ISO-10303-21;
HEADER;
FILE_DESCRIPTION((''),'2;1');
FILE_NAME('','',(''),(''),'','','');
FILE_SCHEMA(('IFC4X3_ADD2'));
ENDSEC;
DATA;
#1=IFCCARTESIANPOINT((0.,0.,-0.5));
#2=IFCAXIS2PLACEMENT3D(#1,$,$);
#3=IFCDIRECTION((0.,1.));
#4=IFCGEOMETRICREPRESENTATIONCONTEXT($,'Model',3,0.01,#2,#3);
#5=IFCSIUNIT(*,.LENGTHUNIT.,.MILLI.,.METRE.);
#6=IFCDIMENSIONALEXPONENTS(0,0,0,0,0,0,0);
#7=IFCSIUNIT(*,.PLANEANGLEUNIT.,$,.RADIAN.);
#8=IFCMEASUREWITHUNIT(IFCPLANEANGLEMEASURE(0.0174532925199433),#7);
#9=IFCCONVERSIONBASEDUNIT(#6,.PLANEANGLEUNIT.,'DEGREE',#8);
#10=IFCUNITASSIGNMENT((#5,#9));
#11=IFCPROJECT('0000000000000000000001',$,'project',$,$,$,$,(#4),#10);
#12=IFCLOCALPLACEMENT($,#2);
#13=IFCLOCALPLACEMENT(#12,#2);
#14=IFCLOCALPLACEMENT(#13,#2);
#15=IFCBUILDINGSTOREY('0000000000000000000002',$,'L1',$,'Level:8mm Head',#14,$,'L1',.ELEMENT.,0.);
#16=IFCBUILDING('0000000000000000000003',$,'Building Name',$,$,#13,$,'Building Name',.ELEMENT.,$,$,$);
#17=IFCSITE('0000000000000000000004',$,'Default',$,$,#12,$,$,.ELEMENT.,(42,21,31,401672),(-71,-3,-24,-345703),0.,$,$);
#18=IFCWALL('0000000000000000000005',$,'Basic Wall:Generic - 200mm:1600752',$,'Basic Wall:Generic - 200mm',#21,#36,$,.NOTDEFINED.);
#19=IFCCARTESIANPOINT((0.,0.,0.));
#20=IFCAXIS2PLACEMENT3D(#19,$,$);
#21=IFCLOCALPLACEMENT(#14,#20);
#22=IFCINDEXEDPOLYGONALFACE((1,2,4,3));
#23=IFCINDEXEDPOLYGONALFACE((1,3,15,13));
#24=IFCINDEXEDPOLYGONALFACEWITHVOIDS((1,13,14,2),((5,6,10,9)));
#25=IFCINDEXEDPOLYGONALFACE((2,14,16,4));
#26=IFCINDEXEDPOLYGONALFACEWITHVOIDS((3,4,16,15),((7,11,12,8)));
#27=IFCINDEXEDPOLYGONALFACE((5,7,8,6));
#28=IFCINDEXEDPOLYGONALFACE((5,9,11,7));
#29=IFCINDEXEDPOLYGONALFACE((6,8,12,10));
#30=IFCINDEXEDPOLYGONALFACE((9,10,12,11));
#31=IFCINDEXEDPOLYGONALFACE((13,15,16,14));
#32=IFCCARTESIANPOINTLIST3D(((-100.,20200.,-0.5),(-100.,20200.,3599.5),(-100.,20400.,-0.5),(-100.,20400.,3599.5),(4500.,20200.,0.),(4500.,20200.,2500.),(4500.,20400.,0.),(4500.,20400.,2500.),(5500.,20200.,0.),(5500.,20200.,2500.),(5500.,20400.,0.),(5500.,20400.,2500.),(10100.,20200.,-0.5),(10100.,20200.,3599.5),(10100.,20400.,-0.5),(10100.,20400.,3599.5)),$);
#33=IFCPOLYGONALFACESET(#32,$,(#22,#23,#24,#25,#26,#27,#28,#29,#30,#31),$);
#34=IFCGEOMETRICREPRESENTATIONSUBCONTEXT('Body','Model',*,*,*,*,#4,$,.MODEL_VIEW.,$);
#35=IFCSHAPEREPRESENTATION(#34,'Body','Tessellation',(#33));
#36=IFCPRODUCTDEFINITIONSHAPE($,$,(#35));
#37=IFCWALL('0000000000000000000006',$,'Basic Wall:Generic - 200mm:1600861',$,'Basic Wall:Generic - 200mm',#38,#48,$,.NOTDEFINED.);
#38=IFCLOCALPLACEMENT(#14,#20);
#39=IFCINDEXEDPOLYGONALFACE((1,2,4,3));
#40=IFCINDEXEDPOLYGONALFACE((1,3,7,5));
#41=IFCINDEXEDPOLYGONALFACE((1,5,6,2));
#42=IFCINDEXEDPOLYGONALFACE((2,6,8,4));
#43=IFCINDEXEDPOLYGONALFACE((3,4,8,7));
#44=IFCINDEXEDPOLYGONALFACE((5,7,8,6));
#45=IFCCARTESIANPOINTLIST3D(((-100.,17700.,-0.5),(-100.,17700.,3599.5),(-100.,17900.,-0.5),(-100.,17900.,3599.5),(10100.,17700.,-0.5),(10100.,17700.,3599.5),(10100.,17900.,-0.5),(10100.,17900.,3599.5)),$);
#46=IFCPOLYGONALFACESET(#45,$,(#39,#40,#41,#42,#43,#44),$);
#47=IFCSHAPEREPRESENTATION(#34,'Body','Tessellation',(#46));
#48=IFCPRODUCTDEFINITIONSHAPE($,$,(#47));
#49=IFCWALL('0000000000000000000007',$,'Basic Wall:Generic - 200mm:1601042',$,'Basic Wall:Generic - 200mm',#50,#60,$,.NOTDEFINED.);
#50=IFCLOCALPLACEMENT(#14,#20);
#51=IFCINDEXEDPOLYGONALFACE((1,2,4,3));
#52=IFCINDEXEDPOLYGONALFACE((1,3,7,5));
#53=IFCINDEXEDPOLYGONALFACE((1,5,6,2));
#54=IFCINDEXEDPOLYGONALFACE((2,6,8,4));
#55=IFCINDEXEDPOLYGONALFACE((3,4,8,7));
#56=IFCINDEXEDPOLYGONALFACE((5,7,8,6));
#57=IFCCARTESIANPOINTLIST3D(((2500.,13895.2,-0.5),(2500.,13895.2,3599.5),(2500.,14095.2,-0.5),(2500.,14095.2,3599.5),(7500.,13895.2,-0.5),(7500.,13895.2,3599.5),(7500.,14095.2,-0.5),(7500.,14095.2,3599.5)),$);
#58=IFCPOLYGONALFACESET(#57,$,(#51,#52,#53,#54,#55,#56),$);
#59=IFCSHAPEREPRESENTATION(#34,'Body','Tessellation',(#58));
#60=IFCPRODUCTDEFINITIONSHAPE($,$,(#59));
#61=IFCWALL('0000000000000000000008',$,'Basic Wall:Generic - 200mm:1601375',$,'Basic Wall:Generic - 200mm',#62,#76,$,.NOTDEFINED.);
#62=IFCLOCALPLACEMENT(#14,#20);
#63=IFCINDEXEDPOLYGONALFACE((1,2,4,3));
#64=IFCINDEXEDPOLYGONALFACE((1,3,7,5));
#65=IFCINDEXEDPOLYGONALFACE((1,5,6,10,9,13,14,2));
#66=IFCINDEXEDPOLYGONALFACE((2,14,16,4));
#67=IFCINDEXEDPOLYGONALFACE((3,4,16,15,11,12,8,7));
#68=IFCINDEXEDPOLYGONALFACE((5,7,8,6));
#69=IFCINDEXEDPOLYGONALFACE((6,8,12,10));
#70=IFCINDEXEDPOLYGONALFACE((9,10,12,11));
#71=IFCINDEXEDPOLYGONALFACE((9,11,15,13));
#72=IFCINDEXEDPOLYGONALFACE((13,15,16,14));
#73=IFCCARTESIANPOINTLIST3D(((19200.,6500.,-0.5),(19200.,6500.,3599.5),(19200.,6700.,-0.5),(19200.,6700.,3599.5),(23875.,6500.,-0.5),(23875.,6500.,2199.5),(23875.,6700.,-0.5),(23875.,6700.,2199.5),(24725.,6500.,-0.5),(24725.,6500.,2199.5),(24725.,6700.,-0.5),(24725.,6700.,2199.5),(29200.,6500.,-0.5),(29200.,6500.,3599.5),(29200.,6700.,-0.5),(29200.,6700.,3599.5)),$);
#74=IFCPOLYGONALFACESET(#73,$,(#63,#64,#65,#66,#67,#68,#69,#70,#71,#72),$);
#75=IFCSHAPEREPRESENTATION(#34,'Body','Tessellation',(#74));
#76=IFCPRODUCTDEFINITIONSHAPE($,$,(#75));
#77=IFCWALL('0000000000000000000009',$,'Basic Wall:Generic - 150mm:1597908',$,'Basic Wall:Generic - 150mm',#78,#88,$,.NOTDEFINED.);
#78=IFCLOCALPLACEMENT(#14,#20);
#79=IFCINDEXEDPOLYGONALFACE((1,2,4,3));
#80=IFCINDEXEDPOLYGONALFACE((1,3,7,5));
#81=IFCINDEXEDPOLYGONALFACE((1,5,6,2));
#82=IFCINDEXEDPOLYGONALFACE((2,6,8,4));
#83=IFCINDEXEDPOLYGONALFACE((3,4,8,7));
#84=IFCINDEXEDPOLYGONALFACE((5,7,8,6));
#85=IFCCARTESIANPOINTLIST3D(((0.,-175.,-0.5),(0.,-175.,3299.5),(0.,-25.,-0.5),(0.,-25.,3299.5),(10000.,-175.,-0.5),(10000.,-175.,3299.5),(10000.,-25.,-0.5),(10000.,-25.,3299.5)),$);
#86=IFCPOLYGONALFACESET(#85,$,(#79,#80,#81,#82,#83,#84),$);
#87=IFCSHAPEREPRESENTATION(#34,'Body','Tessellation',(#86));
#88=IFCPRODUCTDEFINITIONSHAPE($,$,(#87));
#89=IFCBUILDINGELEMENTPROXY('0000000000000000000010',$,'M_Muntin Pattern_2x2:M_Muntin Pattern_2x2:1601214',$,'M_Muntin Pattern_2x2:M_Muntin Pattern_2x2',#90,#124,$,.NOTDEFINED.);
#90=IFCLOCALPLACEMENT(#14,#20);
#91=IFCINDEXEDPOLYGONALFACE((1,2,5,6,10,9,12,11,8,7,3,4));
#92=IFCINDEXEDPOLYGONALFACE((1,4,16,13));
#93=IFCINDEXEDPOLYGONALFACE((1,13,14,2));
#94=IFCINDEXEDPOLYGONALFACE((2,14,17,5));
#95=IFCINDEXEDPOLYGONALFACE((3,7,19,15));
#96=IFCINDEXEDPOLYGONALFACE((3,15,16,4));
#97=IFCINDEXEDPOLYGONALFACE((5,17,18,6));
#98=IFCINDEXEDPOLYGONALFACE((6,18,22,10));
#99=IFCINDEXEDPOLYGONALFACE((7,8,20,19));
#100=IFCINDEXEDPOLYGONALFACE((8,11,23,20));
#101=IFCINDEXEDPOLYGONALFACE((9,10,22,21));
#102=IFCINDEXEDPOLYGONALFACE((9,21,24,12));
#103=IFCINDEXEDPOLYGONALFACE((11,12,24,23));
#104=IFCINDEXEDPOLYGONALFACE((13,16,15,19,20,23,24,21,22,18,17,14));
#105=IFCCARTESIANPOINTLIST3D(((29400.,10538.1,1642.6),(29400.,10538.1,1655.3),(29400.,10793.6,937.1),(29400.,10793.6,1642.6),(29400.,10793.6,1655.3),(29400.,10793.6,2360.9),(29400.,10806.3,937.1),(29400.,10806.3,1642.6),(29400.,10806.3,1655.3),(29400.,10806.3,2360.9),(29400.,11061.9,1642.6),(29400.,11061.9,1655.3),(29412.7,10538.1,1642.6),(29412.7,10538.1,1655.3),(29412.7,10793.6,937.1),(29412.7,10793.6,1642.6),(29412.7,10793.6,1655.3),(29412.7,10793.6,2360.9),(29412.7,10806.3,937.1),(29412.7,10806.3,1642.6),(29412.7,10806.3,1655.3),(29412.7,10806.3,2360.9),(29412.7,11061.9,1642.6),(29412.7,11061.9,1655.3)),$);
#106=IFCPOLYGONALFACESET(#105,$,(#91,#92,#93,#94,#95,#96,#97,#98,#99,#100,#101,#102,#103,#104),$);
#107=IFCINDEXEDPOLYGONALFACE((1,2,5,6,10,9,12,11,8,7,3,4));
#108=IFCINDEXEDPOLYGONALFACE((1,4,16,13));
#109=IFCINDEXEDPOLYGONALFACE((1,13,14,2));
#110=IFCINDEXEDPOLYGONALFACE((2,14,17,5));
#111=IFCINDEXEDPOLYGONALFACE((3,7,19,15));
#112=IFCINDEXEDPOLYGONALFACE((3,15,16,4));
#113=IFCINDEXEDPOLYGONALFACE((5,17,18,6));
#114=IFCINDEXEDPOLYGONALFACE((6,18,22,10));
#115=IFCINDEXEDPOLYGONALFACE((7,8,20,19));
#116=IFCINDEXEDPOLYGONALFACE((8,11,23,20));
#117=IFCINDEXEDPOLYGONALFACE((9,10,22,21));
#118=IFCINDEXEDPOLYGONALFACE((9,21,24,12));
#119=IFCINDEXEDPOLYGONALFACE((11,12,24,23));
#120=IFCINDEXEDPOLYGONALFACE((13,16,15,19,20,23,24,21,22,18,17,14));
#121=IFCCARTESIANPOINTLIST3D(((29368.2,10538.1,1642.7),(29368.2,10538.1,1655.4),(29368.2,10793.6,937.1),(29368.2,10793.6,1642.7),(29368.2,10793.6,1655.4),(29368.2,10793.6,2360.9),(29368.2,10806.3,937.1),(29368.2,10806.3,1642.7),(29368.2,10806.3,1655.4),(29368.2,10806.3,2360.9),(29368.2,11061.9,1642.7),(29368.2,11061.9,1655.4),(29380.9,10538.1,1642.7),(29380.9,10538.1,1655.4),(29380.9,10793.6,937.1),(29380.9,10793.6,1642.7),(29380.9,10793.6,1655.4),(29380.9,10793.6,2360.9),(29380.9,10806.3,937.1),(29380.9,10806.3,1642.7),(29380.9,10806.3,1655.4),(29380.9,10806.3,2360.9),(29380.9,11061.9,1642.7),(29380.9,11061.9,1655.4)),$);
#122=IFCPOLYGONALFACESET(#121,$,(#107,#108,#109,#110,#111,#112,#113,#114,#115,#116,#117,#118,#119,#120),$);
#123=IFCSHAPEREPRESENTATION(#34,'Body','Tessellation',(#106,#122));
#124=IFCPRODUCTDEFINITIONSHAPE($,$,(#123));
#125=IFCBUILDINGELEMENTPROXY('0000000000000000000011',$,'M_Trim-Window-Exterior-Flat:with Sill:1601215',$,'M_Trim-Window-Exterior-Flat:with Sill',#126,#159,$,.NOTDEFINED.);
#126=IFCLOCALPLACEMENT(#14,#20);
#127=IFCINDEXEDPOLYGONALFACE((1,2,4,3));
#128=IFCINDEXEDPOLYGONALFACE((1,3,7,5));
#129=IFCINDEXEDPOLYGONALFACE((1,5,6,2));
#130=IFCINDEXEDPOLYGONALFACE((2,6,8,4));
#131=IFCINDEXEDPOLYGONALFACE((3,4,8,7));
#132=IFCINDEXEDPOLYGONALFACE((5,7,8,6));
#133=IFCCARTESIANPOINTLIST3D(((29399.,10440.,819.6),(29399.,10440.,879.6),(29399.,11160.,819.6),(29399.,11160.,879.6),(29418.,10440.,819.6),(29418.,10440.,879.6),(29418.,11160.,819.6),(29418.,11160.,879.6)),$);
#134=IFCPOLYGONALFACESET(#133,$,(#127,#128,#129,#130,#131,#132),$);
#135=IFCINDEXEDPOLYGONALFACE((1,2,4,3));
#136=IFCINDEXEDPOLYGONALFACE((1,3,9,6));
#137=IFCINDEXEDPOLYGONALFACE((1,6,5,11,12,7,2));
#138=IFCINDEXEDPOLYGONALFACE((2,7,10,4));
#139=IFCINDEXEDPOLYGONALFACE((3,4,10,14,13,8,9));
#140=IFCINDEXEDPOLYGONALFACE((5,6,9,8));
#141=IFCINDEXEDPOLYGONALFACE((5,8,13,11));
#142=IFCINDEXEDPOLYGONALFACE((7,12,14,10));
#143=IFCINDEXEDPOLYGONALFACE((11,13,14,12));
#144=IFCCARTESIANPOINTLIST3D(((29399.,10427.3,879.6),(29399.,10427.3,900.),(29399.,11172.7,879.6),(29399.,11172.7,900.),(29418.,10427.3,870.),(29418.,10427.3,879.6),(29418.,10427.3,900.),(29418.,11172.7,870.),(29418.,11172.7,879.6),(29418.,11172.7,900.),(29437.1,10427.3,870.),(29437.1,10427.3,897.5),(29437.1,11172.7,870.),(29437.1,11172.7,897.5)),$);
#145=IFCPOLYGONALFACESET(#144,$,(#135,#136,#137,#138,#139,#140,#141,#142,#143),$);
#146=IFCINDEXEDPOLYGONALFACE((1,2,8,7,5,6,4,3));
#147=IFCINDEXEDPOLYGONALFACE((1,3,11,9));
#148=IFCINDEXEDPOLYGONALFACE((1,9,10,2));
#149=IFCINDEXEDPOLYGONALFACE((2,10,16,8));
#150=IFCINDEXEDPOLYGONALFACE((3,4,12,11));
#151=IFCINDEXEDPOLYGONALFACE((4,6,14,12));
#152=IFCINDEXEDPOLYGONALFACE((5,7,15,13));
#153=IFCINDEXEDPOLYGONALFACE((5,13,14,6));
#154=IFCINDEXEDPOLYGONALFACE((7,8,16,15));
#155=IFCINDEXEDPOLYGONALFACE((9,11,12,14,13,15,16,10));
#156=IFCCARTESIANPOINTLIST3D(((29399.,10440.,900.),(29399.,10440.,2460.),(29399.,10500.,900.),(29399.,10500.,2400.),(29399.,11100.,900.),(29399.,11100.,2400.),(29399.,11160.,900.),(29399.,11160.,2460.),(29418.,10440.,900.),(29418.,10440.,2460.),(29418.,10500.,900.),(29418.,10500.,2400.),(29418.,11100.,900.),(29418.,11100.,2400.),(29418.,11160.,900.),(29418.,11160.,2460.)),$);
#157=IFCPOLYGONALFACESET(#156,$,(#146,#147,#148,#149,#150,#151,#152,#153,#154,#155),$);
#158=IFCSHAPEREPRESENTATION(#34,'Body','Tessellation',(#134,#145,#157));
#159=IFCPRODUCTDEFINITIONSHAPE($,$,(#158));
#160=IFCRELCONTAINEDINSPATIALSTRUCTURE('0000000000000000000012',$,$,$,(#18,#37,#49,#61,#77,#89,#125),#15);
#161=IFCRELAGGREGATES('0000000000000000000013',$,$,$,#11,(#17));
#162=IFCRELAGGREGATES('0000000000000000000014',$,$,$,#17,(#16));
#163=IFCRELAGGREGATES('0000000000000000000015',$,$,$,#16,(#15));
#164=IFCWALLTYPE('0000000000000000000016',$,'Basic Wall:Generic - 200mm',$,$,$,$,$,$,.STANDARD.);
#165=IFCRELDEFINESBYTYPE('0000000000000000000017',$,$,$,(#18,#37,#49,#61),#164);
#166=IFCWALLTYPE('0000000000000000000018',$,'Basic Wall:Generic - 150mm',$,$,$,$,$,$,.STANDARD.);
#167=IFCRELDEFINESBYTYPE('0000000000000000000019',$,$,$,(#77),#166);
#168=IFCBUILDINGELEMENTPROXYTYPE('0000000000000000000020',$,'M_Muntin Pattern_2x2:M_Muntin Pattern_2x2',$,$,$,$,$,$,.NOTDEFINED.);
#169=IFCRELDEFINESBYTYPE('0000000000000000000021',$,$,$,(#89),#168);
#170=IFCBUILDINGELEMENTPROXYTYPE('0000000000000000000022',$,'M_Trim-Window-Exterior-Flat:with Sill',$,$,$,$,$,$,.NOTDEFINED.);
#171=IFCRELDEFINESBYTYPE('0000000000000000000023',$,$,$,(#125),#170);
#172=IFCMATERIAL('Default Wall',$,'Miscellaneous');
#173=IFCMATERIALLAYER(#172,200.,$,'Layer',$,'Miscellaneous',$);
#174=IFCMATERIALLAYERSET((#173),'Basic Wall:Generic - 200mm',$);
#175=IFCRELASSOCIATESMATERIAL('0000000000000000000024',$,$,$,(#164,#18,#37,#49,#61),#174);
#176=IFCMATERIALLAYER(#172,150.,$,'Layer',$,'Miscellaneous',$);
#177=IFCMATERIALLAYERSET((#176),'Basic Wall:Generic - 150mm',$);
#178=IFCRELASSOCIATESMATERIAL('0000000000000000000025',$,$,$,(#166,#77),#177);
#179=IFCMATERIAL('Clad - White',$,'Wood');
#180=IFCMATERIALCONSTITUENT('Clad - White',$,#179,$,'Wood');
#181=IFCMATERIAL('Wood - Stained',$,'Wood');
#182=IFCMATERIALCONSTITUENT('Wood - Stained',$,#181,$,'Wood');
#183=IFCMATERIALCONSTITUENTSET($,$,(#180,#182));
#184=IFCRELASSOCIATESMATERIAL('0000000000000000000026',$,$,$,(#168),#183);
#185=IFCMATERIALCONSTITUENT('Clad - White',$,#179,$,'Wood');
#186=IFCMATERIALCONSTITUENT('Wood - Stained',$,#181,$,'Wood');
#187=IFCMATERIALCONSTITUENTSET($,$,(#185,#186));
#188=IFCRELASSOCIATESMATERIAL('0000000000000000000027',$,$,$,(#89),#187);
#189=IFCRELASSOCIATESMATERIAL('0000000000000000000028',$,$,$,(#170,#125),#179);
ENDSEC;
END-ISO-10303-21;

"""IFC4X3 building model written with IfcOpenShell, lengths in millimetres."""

from ifc_helpers import new_model, entity, si_unit, converted_unit, direction, frame, frame_2d, origin_2d_with_axis, place, context, subcontext, project, spatial, polyline, rectangle, outline, extrude, source, transform, mapped, material, layer, layer_set, constituent, constituent_set, type_object, type_shapes, element, save


model = new_model("IFC4X3")

# Units and contexts
model_context = context("Model", 3, precision=0.01, world=frame((0.0, 0.0, -0.5)), true_north=direction((0.0, 1.0)))
body_context = subcontext(model_context, "Body", "Model", "MODEL_VIEW")
ifc_project = project(units=[si_unit("LENGTHUNIT", "METRE", prefix="MILLI"), converted_unit("PLANEANGLEUNIT", "DEGREE", entity("IfcPlaneAngleMeasure", 0.0174532925199433), si_unit("PLANEANGLEUNIT", "RADIAN"), dimensions=[0, 0, 0, 0, 0, 0, 0])], contexts=[model_context])

# Site, building, storey
site_placement = place(None, frame((0.0, 0.0, -0.5)))
site = spatial("IfcSite", under=ifc_project, at=site_placement, Name="Default", CompositionType="ELEMENT", RefLatitude=(42, 21, 31, 401672), RefLongitude=(-71, -3, -24, -345703), RefElevation=0.0)
building_placement = place(site_placement, frame((0.0, 0.0, -0.5)))
building = spatial("IfcBuilding", under=site, at=building_placement, Name="Building Name", LongName="Building Name", CompositionType="ELEMENT")
storey_placement = place(building_placement, frame((0.0, 0.0, -0.5)))
storey = spatial("IfcBuildingStorey", under=building, at=storey_placement, Name="L1", ObjectType="Level:8mm Head", LongName="L1", CompositionType="ELEMENT", Elevation=0.0)

# Shared definitions
ifc_material_1 = material(Name="Default Wall", Category="Miscellaneous")
ifc_layer_1 = layer(ifc_material_1, 200.0, Name="Layer", Category="Miscellaneous")
ifc_layer_set_1 = layer_set([ifc_layer_1], Name="Basic Wall:Generic - 200mm")
wall_type_1 = type_object("IfcWallType", Name="Basic Wall:Generic - 200mm", PredefinedType="STANDARD", material=ifc_layer_set_1)

# Wall, opening
wall_1_placement = place(storey_placement, frame((10100.0, 20300.0, 0.0), z_axis=(0.0, 0.0, 1.0), x_axis=(-1.0, 0.0, 0.0)))
wall_1 = element("IfcWall", 1, at=wall_1_placement, inside=storey, type_object=wall_type_1, material=ifc_layer_set_1, Name="Basic Wall:Generic - 200mm:1600752", ObjectType="Basic Wall:Generic - 200mm", PredefinedType="NOTDEFINED", context=body_context, shape_type="SweptSolid", body=[
    extrude(rectangle(XDim=10200.0, YDim=200.0, at=frame_2d((5100.0, 0.0), x_axis=(1.0, 0.0))), frame((0.0, 0.0, -0.5)), (0.0, 0.0, 1.0), 3600.0),
])
opening_1_placement = place(wall_1_placement, frame((5600.0, 100.0, 0.0)))
element("IfcOpeningElement", 2, at=opening_1_placement, cuts=wall_1, PredefinedType="OPENING", context=body_context, shape_type="SweptSolid", body=[
    extrude(rectangle(XDim=2500.0, YDim=1000.0, at=origin_2d_with_axis()), frame((-500.0, -200.0, 1250.0), z_axis=(0.0, 1.0, 0.0), x_axis=(0.0, 0.0, -1.0)), (0.0, 0.0, 1.0), 200.0),
])

# Walls
wall_2_placement = place(storey_placement, frame((10100.0, 17800.0, 0.0), z_axis=(0.0, 0.0, 1.0), x_axis=(-1.0, 0.0, 0.0)))
element("IfcWall", 3, at=wall_2_placement, inside=storey, type_object=wall_type_1, material=ifc_layer_set_1, Name="Basic Wall:Generic - 200mm:1600861", ObjectType="Basic Wall:Generic - 200mm", PredefinedType="NOTDEFINED", context=body_context, shape_type="SweptSolid", body=[
    extrude(rectangle(XDim=10200.0, YDim=200.0, at=frame_2d((5100.0, 0.0), x_axis=(-1.0, 0.0))), frame((0.0, 0.0, -0.5)), (0.0, 0.0, 1.0), 3600.0),
])
wall_3_placement = place(storey_placement, frame((7500.0, 13995.2, 0.0), z_axis=(0.0, 0.0, 1.0), x_axis=(-1.0, 0.0, 0.0)))
element("IfcWall", 4, at=wall_3_placement, inside=storey, type_object=wall_type_1, material=ifc_layer_set_1, Name="Basic Wall:Generic - 200mm:1601042", ObjectType="Basic Wall:Generic - 200mm", PredefinedType="NOTDEFINED", context=body_context, shape_type="SweptSolid", body=[
    extrude(rectangle(XDim=5000.0, YDim=200.0, at=frame_2d((2500.0, 0.0), x_axis=(-1.0, 0.0))), frame((0.0, 0.0, -0.5)), (0.0, 0.0, 1.0), 3600.0),
])

# Wall, opening
wall_4_placement = place(storey_placement, frame((29200.0, 6600.0, 0.0), z_axis=(0.0, 0.0, 1.0), x_axis=(-1.0, 0.0, 0.0)))
wall_4 = element("IfcWall", 5, at=wall_4_placement, inside=storey, type_object=wall_type_1, material=ifc_layer_set_1, Name="Basic Wall:Generic - 200mm:1601375", ObjectType="Basic Wall:Generic - 200mm", PredefinedType="NOTDEFINED", context=body_context, shape_type="SweptSolid", body=[
    extrude(rectangle(XDim=10000.0, YDim=200.0, at=frame_2d((5000.0, 0.0), x_axis=(1.0, 0.0))), frame((0.0, 0.0, -0.5)), (0.0, 0.0, 1.0), 3600.0),
])
opening_2_placement = place(wall_4_placement, frame((5325.0, 100.0, 0.0)))
element("IfcOpeningElement", 6, at=opening_2_placement, cuts=wall_4, PredefinedType="OPENING", context=body_context, shape_type="SweptSolid", body=[
    extrude(rectangle(XDim=2200.0, YDim=850.0, at=frame_2d((1100.0, 425.0), x_axis=(1.0, 0.0))), frame((0.0, 0.0, -0.5), z_axis=(0.0, -1.0, 0.0), x_axis=(0.0, 0.0, 1.0)), (0.0, 0.0, 1.0), 200.0),
])

# Wall
ifc_layer_2 = layer(ifc_material_1, 150.0, Name="Layer", Category="Miscellaneous")
ifc_layer_set_2 = layer_set([ifc_layer_2], Name="Basic Wall:Generic - 150mm")
wall_type_2 = type_object("IfcWallType", Name="Basic Wall:Generic - 150mm", PredefinedType="STANDARD", material=ifc_layer_set_2)
wall_5_placement = place(storey_placement, frame((0.0, -100.0, 0.0)))
element("IfcWall", 7, at=wall_5_placement, inside=storey, type_object=wall_type_2, material=ifc_layer_set_2, Name="Basic Wall:Generic - 150mm:1597908", ObjectType="Basic Wall:Generic - 150mm", PredefinedType="NOTDEFINED", context=body_context, shape_type="SweptSolid", body=[
    extrude(rectangle(XDim=10000.0, YDim=150.0, at=frame_2d((5000.0, 0.0), x_axis=(-1.0, 0.0))), frame((0.0, 0.0, -0.5)), (0.0, 0.0, 1.0), 3300.0),
])

# Building element proxies
ifc_material_2 = material(Name="Clad - White", Category="Wood")
ifc_constituent_1 = constituent(ifc_material_2, Name="Clad - White", Category="Wood")
ifc_material_3 = material(Name="Wood - Stained", Category="Wood")
ifc_constituent_2 = constituent(ifc_material_3, Name="Wood - Stained", Category="Wood")
ifc_constituent_set_1 = constituent_set(constituents=[ifc_constituent_1, ifc_constituent_2])
ifc_constituent_3 = constituent(ifc_material_2, Name="Clad - White", Category="Wood")
ifc_constituent_4 = constituent(ifc_material_3, Name="Wood - Stained", Category="Wood")
ifc_constituent_set_2 = constituent_set(constituents=[ifc_constituent_3, ifc_constituent_4])
building_element_proxy_type_1 = type_object("IfcBuildingElementProxyType", Name="M_Muntin Pattern_2x2:M_Muntin Pattern_2x2", PredefinedType="NOTDEFINED", material=ifc_constituent_set_2)
shared_shape_1 = source(frame((0.0, 0.0, -0.5)), body_context, "Body", "SweptSolid", [
    extrude(outline(polyline([(6.4, -6.4), (711.9, -6.4), (711.9, 6.3), (6.4, 6.3), (6.4, 261.9), (-6.3, 261.9), (-6.3, 6.3), (-711.9, 6.3), (-711.9, -6.4), (-6.3, -6.4), (-6.3, -261.9), (6.4, -261.9), (6.4, -6.4)])), frame((0.0, -22.2, 711.9), z_axis=(0.0, 1.0, 0.0), x_axis=(0.0, 0.0, 1.0)), (0.0, 0.0, 1.0), 12.7),
    extrude(outline(polyline([(6.4, -6.4), (711.9, -6.4), (711.9, 6.3), (6.4, 6.3), (6.4, 261.9), (-6.3, 261.9), (-6.3, 6.3), (-711.9, 6.3), (-711.9, -6.4), (-6.3, -6.4), (-6.3, -261.9), (6.4, -261.9), (6.4, -6.4)])), frame((0.0, 9.5, 711.9), z_axis=(0.0, 1.0, 0.0), x_axis=(0.0, 0.0, 1.0)), (0.0, 0.0, 1.0), 12.7),
])
type_shapes(building_element_proxy_type_1, [shared_shape_1])
proxy_1_placement = place(storey_placement, frame((29390.5, 10800.0, 938.1), z_axis=(0.0, 0.0, 1.0), x_axis=(0.0, 1.0, 0.0)))
element("IfcBuildingElementProxy", 8, at=proxy_1_placement, inside=storey, type_object=building_element_proxy_type_1, material=ifc_constituent_set_1, Name="M_Muntin Pattern_2x2:M_Muntin Pattern_2x2:1601214", ObjectType="M_Muntin Pattern_2x2:M_Muntin Pattern_2x2", PredefinedType="NOTDEFINED", context=body_context, shape_type="MappedRepresentation", body=[
    mapped(shared_shape_1, transform((0.0, 0.0, -0.5), scale=1.0)),
])
building_element_proxy_type_2 = type_object("IfcBuildingElementProxyType", Name="M_Trim-Window-Exterior-Flat:with Sill", PredefinedType="NOTDEFINED", material=ifc_material_2)
shared_shape_2 = source(frame((0.0, 0.0, -0.5)), body_context, "Body", "SweptSolid", [
    extrude(rectangle(XDim=720.0, YDim=60.0, at=frame_2d((0.0, 0.0), x_axis=(1.0, 0.0))), frame((0.0, -1550.4, 0.0), z_axis=(0.0, 0.0, 1.0), x_axis=(-1.0, 0.0, 0.0)), (0.0, 0.0, 1.0), 19.1),
    extrude(outline(polyline([(-19.0, -15.2), (0.0, -15.2), (0.0, -5.7), (19.0, -5.7), (19.0, 14.8), (0.0, 14.8), (-19.0, 12.3), (-19.0, -15.2)])), frame((-372.7, -1514.8, 19.0), z_axis=(1.0, 0.0, 0.0), x_axis=(0.0, 0.0, -1.0)), (0.0, 0.0, 1.0), 745.4),
    extrude(outline(polyline([(-795.0, -360.0), (765.0, -360.0), (765.0, -300.0), (-735.0, -300.0), (-735.0, 300.0), (765.0, 300.0), (765.0, 360.0), (-795.0, 360.0), (-795.0, -360.0)])), frame((0.0, -735.0, 0.0), z_axis=(0.0, 0.0, 1.0), x_axis=(0.0, -1.0, 0.0)), (0.0, 0.0, 1.0), 19.1),
])
type_shapes(building_element_proxy_type_2, [shared_shape_2])
proxy_2_placement = place(storey_placement, frame((29400.0, 10800.0, 2400.0), z_axis=(1.0, 0.0, 0.0), x_axis=(0.0, 1.0, 0.0)))
element("IfcBuildingElementProxy", 9, at=proxy_2_placement, inside=storey, type_object=building_element_proxy_type_2, material=ifc_material_2, Name="M_Trim-Window-Exterior-Flat:with Sill:1601215", ObjectType="M_Trim-Window-Exterior-Flat:with Sill", PredefinedType="NOTDEFINED", context=body_context, shape_type="MappedRepresentation", body=[
    mapped(shared_shape_2, transform((0.0, 0.0, -0.5), scale=1.0)),
])

save(model, "model.ifc")
